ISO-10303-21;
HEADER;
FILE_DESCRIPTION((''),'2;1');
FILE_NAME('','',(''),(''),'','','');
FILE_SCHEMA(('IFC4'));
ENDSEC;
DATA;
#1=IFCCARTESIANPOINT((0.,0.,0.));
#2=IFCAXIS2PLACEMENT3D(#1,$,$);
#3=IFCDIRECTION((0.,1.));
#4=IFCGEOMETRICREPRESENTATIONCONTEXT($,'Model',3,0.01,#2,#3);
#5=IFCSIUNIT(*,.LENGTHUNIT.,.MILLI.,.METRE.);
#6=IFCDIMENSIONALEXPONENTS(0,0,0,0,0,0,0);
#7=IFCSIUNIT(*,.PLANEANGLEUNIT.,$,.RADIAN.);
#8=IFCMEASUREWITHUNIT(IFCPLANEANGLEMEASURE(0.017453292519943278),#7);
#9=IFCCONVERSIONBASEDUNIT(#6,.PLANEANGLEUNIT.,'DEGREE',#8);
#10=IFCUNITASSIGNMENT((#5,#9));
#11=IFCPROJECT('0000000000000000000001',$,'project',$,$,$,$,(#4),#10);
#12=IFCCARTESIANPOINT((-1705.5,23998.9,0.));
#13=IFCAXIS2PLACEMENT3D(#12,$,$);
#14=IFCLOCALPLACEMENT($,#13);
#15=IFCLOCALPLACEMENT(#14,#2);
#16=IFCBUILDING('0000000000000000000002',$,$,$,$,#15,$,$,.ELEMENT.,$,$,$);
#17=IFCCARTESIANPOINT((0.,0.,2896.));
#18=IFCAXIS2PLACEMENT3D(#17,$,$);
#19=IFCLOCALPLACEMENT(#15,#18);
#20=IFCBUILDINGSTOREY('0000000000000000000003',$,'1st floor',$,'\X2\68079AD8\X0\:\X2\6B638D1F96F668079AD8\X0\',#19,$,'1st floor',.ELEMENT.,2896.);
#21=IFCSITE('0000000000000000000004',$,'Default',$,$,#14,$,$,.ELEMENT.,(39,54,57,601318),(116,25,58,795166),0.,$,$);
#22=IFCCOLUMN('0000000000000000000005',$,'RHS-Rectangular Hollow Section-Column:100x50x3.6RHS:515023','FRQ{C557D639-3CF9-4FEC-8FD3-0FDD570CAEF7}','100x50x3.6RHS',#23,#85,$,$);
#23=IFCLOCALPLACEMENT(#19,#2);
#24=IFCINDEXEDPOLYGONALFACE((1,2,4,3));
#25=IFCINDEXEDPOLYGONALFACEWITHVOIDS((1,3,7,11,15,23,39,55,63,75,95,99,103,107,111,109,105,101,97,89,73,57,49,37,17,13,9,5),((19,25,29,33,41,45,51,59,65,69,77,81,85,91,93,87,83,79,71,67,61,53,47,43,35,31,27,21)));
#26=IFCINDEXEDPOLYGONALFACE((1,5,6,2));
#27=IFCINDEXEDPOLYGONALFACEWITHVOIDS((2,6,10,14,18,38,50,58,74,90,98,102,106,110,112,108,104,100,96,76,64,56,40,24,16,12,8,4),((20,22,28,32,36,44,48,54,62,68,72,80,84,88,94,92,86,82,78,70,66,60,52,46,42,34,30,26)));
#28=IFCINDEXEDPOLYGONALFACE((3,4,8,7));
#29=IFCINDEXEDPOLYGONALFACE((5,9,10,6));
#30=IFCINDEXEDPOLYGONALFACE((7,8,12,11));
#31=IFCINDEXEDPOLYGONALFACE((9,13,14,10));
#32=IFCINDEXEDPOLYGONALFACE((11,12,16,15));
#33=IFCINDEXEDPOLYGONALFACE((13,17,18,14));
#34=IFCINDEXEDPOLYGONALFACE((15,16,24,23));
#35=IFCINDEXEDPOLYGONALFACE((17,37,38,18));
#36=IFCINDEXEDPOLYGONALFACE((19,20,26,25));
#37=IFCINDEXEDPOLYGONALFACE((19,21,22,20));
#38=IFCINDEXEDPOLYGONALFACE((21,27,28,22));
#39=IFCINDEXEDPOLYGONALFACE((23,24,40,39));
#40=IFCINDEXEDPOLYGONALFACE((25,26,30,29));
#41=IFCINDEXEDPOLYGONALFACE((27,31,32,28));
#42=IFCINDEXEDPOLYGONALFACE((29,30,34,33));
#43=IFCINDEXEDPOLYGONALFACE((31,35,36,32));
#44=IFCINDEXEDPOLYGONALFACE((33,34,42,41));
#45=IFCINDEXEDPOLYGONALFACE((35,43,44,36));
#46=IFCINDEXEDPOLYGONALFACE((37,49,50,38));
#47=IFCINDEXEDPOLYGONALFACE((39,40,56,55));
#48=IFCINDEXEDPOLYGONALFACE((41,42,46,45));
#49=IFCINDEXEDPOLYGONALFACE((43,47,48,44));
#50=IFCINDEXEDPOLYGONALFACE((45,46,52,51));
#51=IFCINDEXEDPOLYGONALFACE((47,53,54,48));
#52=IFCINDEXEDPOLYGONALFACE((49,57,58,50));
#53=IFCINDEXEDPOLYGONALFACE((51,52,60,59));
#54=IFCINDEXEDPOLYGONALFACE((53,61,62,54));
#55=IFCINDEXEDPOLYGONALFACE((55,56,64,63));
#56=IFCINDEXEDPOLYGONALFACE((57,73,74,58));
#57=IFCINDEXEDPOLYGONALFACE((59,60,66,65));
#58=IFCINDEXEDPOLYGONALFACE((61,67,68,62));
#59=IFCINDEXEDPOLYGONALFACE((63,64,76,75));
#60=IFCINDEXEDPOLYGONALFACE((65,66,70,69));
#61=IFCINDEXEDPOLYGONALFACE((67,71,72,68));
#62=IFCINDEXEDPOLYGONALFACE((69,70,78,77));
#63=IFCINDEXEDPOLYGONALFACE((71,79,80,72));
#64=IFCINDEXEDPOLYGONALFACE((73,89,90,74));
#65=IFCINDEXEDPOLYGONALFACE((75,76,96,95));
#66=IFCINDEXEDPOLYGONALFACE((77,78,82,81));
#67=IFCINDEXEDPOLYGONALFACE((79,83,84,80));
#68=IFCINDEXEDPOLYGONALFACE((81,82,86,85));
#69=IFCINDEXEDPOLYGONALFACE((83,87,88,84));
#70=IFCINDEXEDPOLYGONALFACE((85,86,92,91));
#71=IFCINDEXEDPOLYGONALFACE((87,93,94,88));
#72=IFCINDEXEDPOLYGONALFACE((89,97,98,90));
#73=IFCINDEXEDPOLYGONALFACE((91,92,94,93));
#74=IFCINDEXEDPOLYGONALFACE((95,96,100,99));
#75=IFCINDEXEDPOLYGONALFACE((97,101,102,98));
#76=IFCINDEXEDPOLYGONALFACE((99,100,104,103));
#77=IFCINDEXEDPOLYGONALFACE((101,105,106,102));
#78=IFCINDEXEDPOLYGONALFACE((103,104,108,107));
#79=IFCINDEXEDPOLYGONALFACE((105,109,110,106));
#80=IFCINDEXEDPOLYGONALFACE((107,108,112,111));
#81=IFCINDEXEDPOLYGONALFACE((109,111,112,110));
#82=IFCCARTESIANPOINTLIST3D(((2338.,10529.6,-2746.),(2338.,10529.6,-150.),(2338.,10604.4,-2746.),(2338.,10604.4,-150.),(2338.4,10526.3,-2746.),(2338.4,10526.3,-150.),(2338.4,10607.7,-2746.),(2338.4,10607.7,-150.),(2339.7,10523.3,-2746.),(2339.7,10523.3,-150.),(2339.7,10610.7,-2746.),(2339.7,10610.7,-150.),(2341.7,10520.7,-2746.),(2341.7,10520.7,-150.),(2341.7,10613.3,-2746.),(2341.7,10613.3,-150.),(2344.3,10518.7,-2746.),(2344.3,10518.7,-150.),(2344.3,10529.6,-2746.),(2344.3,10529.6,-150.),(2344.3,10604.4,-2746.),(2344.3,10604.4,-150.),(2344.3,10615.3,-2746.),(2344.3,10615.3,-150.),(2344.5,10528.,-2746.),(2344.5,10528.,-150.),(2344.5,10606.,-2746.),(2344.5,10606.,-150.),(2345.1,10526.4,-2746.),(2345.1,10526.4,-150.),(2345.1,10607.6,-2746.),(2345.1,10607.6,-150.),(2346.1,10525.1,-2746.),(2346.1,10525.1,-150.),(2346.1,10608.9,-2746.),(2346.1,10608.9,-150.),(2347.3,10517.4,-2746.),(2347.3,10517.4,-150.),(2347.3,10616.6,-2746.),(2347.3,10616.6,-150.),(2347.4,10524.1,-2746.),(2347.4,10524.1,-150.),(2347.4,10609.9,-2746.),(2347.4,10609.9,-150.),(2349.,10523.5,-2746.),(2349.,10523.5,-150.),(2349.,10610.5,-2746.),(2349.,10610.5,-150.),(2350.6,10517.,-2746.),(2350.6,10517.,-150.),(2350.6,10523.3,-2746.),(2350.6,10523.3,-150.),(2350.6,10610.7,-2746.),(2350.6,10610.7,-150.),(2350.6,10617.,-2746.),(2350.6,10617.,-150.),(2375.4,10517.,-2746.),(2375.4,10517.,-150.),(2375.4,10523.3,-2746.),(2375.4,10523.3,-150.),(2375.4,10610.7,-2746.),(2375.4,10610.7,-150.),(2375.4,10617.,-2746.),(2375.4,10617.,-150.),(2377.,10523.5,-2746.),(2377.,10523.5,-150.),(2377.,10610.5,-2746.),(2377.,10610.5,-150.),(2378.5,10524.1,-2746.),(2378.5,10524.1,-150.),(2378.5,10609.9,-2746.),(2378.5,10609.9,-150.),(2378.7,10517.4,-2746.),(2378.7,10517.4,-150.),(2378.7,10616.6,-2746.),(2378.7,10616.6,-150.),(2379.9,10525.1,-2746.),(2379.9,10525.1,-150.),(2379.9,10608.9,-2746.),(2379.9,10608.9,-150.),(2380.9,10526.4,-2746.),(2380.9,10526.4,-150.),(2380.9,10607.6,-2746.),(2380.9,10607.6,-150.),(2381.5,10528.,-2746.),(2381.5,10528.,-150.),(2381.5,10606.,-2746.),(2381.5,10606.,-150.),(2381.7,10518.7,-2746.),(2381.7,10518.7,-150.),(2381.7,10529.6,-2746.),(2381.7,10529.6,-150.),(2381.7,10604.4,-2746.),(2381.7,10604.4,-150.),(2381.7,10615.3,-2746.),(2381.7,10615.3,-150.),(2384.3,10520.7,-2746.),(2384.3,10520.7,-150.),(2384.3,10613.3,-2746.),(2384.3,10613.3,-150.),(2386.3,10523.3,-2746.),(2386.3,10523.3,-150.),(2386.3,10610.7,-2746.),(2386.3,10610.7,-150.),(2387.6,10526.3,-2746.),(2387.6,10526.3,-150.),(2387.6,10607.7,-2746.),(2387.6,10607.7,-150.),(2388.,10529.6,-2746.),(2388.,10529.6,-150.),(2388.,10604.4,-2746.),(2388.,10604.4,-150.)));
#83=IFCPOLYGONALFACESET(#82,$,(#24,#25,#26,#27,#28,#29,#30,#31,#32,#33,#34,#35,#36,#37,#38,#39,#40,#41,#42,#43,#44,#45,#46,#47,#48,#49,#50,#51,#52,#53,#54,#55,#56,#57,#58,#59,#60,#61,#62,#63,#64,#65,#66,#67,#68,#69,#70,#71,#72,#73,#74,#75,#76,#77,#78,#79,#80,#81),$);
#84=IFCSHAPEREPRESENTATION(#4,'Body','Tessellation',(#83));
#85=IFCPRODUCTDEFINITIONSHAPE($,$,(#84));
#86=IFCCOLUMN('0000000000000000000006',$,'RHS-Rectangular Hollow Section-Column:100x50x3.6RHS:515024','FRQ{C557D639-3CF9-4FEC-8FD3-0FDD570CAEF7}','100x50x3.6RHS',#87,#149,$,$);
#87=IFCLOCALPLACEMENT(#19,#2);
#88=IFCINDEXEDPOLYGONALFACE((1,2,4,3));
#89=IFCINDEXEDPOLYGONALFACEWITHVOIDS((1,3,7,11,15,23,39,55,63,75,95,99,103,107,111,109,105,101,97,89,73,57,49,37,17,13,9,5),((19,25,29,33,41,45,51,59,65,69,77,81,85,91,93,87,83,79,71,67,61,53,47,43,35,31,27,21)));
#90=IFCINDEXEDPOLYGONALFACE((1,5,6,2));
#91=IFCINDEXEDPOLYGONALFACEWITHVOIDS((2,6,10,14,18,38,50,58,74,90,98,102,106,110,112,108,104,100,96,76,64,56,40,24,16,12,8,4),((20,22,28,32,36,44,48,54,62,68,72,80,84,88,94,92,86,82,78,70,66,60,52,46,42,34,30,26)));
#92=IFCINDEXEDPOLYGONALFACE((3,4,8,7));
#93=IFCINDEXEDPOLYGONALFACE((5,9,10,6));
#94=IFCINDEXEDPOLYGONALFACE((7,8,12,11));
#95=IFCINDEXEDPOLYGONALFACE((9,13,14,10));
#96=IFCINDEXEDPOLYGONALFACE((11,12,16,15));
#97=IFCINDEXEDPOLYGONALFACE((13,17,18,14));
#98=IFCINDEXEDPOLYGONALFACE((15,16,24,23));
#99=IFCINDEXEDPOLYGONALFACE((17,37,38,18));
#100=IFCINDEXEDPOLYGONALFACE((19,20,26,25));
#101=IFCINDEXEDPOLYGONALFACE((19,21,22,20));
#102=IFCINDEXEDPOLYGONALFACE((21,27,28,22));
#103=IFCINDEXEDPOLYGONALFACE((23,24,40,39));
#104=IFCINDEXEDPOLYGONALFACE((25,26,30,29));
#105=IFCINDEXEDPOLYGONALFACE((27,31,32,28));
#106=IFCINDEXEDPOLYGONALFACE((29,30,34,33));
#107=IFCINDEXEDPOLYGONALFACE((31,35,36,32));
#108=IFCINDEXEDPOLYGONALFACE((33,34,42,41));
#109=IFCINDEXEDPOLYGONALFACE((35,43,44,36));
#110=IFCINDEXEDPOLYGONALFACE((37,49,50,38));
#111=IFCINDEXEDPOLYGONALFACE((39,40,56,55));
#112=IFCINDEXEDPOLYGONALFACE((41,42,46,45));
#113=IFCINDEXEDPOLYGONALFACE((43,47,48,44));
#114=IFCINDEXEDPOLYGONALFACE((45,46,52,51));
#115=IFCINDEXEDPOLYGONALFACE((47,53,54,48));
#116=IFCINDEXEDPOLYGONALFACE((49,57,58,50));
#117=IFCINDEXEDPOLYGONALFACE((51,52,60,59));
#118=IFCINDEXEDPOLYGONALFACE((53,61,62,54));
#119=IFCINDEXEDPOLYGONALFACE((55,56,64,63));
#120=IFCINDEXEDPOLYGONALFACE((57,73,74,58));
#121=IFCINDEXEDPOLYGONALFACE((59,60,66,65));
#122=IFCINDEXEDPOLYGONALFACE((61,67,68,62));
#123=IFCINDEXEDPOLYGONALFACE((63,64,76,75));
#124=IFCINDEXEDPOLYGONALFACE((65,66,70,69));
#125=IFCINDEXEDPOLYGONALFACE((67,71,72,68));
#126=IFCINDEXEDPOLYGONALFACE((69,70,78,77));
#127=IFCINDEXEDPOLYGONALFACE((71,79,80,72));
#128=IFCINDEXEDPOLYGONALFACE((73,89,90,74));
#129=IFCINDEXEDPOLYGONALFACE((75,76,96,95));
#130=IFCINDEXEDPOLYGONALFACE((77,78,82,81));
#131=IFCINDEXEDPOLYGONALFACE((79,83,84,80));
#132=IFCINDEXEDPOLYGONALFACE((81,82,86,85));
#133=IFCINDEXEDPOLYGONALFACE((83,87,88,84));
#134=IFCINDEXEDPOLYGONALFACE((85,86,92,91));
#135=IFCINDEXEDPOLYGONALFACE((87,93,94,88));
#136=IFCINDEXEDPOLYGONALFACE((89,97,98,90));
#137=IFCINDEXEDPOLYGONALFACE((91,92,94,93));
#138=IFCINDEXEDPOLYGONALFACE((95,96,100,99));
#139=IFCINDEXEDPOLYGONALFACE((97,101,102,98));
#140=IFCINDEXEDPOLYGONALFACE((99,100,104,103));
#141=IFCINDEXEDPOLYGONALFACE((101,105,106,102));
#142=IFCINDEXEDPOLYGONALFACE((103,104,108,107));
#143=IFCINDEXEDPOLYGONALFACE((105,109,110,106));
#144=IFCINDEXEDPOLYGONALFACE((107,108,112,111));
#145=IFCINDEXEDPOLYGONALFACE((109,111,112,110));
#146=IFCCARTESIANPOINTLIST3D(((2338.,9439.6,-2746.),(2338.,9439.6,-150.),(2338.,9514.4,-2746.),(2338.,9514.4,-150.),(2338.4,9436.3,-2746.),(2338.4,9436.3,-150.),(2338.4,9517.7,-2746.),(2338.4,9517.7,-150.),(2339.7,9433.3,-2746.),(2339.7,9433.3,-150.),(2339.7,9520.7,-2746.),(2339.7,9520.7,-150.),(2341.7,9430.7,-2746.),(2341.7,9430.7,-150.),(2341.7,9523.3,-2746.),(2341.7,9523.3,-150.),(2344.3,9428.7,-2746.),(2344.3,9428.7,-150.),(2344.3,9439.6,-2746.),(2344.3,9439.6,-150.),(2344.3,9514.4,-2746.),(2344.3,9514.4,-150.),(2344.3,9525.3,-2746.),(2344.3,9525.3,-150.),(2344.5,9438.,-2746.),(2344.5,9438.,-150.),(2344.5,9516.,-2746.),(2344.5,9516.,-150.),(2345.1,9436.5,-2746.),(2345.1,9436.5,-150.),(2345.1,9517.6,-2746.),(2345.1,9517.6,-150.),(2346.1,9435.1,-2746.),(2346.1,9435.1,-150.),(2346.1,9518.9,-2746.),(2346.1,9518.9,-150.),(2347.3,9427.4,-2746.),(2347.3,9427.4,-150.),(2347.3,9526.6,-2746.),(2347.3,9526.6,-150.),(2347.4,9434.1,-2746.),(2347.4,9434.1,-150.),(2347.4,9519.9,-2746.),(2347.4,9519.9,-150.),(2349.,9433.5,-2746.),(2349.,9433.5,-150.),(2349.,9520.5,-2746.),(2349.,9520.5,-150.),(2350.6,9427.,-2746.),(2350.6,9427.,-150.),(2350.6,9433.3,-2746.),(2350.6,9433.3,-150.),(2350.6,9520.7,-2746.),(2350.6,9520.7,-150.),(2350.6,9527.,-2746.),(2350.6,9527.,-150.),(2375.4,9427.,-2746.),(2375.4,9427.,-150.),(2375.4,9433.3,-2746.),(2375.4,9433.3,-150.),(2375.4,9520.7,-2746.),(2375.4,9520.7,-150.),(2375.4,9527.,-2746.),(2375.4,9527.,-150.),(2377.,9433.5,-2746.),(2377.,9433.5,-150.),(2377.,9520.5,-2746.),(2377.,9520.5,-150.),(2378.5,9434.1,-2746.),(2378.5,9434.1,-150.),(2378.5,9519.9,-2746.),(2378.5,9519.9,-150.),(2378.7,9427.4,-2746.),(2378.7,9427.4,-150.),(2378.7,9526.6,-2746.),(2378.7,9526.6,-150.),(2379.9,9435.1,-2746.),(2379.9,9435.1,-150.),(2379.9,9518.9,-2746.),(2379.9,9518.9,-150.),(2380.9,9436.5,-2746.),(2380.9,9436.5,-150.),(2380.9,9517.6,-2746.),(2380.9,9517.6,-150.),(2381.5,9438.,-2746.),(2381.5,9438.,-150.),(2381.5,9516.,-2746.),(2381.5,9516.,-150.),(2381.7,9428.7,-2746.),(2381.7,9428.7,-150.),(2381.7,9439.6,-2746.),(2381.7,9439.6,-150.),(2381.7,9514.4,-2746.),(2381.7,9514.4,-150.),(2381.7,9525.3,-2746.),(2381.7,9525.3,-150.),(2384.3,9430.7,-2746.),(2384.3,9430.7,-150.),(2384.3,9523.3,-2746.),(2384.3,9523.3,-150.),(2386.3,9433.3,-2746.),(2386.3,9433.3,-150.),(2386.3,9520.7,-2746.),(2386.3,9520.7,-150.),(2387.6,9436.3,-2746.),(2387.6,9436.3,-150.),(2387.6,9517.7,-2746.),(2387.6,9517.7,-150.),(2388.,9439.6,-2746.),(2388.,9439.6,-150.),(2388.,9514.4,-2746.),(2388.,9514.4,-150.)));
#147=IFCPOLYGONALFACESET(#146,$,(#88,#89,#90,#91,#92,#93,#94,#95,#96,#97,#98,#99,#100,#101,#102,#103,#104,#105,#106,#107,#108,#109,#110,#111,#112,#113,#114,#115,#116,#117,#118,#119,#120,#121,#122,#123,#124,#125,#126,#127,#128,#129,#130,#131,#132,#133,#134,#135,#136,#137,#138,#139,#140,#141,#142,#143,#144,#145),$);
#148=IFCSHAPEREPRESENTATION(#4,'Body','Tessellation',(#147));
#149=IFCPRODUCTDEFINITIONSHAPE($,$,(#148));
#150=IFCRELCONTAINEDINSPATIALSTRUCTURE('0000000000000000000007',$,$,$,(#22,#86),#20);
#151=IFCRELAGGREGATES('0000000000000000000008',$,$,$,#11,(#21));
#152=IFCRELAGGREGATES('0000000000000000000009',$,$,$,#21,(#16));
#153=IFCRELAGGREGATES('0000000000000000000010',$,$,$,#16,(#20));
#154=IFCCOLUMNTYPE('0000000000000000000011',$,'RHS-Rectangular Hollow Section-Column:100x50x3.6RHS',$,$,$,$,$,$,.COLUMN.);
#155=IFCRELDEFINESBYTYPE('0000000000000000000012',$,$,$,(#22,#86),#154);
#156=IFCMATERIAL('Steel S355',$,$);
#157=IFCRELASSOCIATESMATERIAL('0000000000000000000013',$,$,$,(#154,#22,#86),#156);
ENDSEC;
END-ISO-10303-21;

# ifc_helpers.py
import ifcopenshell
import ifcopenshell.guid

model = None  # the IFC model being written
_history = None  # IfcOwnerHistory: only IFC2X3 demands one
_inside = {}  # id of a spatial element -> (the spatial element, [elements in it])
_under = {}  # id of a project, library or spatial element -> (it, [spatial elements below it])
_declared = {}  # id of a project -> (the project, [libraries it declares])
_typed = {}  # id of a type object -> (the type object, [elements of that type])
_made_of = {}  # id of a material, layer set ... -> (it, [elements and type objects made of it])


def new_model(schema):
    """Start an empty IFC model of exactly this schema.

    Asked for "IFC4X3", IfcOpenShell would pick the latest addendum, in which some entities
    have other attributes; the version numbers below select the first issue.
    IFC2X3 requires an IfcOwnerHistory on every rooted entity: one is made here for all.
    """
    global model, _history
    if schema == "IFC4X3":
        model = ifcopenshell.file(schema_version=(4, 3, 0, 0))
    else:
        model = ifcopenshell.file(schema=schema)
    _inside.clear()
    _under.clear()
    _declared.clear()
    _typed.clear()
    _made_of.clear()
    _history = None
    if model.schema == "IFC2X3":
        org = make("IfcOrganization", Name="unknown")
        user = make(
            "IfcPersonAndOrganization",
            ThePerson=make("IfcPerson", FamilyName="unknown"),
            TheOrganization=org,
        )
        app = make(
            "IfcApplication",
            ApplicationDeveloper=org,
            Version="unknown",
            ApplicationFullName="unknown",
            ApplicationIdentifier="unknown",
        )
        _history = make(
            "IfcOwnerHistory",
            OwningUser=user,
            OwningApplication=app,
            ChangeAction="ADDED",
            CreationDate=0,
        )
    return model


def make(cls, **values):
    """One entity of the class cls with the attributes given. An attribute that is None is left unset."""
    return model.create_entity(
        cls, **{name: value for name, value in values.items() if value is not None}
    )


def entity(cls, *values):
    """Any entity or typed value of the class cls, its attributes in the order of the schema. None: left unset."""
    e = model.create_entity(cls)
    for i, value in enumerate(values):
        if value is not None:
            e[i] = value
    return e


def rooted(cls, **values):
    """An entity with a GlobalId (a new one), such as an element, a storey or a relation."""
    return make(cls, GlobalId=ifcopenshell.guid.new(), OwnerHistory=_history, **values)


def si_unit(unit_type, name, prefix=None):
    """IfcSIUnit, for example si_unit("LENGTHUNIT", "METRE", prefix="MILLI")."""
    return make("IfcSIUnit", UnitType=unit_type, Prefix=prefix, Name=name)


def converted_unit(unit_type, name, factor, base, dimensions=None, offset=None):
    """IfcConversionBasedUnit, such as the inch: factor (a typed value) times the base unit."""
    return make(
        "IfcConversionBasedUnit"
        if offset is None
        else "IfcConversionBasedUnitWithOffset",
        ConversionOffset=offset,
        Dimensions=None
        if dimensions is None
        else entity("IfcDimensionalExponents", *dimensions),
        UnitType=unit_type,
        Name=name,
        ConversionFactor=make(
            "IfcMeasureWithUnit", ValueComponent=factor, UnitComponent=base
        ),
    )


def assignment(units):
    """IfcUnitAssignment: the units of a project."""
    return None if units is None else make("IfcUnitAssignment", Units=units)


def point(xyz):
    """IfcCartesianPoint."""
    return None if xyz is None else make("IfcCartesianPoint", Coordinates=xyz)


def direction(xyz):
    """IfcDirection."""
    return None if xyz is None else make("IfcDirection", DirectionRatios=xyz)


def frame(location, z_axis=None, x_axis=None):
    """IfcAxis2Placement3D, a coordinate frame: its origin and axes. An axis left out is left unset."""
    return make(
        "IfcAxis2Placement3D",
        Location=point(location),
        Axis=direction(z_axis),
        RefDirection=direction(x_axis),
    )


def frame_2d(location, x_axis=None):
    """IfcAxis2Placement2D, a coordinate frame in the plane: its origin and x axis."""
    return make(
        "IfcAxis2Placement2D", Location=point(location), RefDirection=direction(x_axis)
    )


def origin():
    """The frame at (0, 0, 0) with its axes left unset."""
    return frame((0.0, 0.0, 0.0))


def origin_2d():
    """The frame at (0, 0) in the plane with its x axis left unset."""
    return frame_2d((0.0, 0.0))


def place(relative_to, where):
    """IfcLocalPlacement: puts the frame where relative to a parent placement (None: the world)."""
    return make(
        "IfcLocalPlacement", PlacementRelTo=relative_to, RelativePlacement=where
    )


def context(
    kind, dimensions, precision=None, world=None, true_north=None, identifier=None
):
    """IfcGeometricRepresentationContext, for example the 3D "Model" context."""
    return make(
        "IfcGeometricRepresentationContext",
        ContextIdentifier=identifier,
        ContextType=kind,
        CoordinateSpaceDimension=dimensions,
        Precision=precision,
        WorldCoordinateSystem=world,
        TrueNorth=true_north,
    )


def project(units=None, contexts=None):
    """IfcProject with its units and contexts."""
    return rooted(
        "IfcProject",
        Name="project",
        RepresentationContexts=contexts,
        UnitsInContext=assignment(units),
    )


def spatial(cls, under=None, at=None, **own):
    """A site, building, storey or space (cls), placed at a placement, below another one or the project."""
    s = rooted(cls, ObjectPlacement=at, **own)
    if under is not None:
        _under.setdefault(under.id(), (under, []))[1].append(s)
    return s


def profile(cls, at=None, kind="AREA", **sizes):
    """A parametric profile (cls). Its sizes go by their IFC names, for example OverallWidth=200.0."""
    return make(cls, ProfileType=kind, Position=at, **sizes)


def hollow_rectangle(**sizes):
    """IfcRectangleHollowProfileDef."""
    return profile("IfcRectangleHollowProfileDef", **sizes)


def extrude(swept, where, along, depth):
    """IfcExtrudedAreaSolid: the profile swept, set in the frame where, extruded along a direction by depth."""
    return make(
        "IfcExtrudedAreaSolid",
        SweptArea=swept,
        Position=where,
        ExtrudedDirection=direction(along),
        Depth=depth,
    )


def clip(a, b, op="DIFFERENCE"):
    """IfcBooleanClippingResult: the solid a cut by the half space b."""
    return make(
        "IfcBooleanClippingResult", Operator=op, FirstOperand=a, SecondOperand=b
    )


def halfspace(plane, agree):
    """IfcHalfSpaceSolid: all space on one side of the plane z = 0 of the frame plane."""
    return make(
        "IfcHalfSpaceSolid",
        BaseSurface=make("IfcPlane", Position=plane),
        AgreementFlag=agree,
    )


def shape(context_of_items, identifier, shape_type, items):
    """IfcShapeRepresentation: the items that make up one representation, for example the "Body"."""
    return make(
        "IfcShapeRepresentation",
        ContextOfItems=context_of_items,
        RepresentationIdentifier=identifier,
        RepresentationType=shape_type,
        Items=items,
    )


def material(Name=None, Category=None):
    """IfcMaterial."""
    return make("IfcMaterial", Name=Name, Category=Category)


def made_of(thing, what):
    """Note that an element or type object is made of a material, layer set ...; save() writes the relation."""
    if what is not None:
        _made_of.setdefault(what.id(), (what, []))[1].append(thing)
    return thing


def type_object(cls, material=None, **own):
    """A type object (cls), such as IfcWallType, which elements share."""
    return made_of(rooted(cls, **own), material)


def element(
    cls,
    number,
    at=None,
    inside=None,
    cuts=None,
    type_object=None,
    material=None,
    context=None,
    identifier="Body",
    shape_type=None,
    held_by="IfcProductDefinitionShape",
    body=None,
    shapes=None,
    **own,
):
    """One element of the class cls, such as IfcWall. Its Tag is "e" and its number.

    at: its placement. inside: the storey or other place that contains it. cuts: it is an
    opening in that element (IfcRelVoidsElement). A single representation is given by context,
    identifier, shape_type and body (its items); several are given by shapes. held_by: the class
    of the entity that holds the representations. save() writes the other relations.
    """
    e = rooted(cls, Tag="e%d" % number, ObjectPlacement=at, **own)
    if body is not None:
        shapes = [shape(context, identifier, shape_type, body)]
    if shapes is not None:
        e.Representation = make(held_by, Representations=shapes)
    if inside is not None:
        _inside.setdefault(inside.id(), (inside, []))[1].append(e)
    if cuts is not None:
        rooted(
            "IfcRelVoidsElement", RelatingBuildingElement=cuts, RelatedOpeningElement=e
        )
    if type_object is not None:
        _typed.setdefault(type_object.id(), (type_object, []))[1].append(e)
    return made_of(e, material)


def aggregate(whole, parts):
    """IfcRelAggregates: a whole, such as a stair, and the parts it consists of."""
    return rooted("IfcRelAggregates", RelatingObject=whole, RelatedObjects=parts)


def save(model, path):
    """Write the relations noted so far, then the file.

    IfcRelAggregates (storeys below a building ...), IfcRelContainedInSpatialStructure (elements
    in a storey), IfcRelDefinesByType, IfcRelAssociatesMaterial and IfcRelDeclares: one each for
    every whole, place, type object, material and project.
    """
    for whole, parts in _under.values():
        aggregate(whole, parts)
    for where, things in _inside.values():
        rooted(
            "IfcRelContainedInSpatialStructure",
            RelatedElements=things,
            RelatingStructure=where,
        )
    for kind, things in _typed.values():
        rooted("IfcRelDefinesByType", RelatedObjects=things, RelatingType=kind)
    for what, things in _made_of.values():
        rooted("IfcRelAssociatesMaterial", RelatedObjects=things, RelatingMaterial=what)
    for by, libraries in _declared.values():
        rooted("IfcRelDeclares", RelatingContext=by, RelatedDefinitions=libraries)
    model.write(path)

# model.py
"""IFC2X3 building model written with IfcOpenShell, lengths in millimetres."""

from ifc_helpers import new_model, entity, si_unit, converted_unit, direction, frame, origin, origin_2d, place, context, project, spatial, hollow_rectangle, extrude, clip, halfspace, material, type_object, element, save


model = new_model("IFC2X3")

# Units and contexts
model_context = context("Model", 3, precision=0.01, world=origin(), true_north=direction((0.0, 1.0)))
ifc_project = project(units=[si_unit("LENGTHUNIT", "METRE", prefix="MILLI"), converted_unit("PLANEANGLEUNIT", "DEGREE", entity("IfcPlaneAngleMeasure", 0.017453292519943278), si_unit("PLANEANGLEUNIT", "RADIAN"), dimensions=[0, 0, 0, 0, 0, 0, 0])], contexts=[model_context])

# Site, building, storey
site_placement = place(None, frame((-1705.5, 23998.9, 0.0)))
site = spatial("IfcSite", under=ifc_project, at=site_placement, Name="Default", CompositionType="ELEMENT", RefLatitude=(39, 54, 57, 601318), RefLongitude=(116, 25, 58, 795166), RefElevation=0.0)
building_placement = place(site_placement, origin())
building = spatial("IfcBuilding", under=site, at=building_placement, CompositionType="ELEMENT")
storey_placement = place(building_placement, frame((0.0, 0.0, 2896.0)))
storey = spatial("IfcBuildingStorey", under=building, at=storey_placement, Name="1st floor", ObjectType="标高:正负零标高", LongName="1st floor", CompositionType="ELEMENT", Elevation=2896.0)

# Columns
ifc_material_1 = material(Name="Steel S355")
column_type_1 = type_object("IfcColumnType", Name="RHS-Rectangular Hollow Section-Column:100x50x3.6RHS", PredefinedType="COLUMN", material=ifc_material_1)
column_1_placement = place(storey_placement, frame((2363.0, 10567.0, -150.0), z_axis=(0.0, 0.0, 1.0), x_axis=(-1.0, 0.0, 0.0)))
element("IfcColumn", 1, at=column_1_placement, inside=storey, type_object=column_type_1, material=ifc_material_1, Name="RHS-Rectangular Hollow Section-Column:100x50x3.6RHS:515023", Description="FRQ{C557D639-3CF9-4FEC-8FD3-0FDD570CAEF7}", ObjectType="100x50x3.6RHS", context=model_context, shape_type="Clipping", body=[
    clip(extrude(hollow_rectangle(XDim=50.0, YDim=100.0, WallThickness=6.3, InnerFilletRadius=6.3, OuterFilletRadius=12.6, at=origin_2d()), origin(), (0.0, 0.0, -1.0), 2651.9), halfspace(frame((2363.0, 10567.0, -2596.0), z_axis=(0.0, 0.0, 1.0), x_axis=(-1.0, 0.0, 0.0)), True)),
])
column_2_placement = place(storey_placement, frame((2363.0, 9477.0, -150.0), z_axis=(0.0, 0.0, 1.0), x_axis=(-1.0, 0.0, 0.0)))
element("IfcColumn", 2, at=column_2_placement, inside=storey, type_object=column_type_1, material=ifc_material_1, Name="RHS-Rectangular Hollow Section-Column:100x50x3.6RHS:515024", Description="FRQ{C557D639-3CF9-4FEC-8FD3-0FDD570CAEF7}", ObjectType="100x50x3.6RHS", context=model_context, shape_type="Clipping", body=[
    clip(extrude(hollow_rectangle(XDim=50.0, YDim=100.0, WallThickness=6.3, InnerFilletRadius=6.3, OuterFilletRadius=12.6, at=origin_2d()), origin(), (0.0, 0.0, -1.0), 2651.9), halfspace(frame((2363.0, 9477.0, -2596.0), z_axis=(0.0, 0.0, 1.0), x_axis=(-1.0, 0.0, 0.0)), True)),
])

save(model, "model.ifc")
